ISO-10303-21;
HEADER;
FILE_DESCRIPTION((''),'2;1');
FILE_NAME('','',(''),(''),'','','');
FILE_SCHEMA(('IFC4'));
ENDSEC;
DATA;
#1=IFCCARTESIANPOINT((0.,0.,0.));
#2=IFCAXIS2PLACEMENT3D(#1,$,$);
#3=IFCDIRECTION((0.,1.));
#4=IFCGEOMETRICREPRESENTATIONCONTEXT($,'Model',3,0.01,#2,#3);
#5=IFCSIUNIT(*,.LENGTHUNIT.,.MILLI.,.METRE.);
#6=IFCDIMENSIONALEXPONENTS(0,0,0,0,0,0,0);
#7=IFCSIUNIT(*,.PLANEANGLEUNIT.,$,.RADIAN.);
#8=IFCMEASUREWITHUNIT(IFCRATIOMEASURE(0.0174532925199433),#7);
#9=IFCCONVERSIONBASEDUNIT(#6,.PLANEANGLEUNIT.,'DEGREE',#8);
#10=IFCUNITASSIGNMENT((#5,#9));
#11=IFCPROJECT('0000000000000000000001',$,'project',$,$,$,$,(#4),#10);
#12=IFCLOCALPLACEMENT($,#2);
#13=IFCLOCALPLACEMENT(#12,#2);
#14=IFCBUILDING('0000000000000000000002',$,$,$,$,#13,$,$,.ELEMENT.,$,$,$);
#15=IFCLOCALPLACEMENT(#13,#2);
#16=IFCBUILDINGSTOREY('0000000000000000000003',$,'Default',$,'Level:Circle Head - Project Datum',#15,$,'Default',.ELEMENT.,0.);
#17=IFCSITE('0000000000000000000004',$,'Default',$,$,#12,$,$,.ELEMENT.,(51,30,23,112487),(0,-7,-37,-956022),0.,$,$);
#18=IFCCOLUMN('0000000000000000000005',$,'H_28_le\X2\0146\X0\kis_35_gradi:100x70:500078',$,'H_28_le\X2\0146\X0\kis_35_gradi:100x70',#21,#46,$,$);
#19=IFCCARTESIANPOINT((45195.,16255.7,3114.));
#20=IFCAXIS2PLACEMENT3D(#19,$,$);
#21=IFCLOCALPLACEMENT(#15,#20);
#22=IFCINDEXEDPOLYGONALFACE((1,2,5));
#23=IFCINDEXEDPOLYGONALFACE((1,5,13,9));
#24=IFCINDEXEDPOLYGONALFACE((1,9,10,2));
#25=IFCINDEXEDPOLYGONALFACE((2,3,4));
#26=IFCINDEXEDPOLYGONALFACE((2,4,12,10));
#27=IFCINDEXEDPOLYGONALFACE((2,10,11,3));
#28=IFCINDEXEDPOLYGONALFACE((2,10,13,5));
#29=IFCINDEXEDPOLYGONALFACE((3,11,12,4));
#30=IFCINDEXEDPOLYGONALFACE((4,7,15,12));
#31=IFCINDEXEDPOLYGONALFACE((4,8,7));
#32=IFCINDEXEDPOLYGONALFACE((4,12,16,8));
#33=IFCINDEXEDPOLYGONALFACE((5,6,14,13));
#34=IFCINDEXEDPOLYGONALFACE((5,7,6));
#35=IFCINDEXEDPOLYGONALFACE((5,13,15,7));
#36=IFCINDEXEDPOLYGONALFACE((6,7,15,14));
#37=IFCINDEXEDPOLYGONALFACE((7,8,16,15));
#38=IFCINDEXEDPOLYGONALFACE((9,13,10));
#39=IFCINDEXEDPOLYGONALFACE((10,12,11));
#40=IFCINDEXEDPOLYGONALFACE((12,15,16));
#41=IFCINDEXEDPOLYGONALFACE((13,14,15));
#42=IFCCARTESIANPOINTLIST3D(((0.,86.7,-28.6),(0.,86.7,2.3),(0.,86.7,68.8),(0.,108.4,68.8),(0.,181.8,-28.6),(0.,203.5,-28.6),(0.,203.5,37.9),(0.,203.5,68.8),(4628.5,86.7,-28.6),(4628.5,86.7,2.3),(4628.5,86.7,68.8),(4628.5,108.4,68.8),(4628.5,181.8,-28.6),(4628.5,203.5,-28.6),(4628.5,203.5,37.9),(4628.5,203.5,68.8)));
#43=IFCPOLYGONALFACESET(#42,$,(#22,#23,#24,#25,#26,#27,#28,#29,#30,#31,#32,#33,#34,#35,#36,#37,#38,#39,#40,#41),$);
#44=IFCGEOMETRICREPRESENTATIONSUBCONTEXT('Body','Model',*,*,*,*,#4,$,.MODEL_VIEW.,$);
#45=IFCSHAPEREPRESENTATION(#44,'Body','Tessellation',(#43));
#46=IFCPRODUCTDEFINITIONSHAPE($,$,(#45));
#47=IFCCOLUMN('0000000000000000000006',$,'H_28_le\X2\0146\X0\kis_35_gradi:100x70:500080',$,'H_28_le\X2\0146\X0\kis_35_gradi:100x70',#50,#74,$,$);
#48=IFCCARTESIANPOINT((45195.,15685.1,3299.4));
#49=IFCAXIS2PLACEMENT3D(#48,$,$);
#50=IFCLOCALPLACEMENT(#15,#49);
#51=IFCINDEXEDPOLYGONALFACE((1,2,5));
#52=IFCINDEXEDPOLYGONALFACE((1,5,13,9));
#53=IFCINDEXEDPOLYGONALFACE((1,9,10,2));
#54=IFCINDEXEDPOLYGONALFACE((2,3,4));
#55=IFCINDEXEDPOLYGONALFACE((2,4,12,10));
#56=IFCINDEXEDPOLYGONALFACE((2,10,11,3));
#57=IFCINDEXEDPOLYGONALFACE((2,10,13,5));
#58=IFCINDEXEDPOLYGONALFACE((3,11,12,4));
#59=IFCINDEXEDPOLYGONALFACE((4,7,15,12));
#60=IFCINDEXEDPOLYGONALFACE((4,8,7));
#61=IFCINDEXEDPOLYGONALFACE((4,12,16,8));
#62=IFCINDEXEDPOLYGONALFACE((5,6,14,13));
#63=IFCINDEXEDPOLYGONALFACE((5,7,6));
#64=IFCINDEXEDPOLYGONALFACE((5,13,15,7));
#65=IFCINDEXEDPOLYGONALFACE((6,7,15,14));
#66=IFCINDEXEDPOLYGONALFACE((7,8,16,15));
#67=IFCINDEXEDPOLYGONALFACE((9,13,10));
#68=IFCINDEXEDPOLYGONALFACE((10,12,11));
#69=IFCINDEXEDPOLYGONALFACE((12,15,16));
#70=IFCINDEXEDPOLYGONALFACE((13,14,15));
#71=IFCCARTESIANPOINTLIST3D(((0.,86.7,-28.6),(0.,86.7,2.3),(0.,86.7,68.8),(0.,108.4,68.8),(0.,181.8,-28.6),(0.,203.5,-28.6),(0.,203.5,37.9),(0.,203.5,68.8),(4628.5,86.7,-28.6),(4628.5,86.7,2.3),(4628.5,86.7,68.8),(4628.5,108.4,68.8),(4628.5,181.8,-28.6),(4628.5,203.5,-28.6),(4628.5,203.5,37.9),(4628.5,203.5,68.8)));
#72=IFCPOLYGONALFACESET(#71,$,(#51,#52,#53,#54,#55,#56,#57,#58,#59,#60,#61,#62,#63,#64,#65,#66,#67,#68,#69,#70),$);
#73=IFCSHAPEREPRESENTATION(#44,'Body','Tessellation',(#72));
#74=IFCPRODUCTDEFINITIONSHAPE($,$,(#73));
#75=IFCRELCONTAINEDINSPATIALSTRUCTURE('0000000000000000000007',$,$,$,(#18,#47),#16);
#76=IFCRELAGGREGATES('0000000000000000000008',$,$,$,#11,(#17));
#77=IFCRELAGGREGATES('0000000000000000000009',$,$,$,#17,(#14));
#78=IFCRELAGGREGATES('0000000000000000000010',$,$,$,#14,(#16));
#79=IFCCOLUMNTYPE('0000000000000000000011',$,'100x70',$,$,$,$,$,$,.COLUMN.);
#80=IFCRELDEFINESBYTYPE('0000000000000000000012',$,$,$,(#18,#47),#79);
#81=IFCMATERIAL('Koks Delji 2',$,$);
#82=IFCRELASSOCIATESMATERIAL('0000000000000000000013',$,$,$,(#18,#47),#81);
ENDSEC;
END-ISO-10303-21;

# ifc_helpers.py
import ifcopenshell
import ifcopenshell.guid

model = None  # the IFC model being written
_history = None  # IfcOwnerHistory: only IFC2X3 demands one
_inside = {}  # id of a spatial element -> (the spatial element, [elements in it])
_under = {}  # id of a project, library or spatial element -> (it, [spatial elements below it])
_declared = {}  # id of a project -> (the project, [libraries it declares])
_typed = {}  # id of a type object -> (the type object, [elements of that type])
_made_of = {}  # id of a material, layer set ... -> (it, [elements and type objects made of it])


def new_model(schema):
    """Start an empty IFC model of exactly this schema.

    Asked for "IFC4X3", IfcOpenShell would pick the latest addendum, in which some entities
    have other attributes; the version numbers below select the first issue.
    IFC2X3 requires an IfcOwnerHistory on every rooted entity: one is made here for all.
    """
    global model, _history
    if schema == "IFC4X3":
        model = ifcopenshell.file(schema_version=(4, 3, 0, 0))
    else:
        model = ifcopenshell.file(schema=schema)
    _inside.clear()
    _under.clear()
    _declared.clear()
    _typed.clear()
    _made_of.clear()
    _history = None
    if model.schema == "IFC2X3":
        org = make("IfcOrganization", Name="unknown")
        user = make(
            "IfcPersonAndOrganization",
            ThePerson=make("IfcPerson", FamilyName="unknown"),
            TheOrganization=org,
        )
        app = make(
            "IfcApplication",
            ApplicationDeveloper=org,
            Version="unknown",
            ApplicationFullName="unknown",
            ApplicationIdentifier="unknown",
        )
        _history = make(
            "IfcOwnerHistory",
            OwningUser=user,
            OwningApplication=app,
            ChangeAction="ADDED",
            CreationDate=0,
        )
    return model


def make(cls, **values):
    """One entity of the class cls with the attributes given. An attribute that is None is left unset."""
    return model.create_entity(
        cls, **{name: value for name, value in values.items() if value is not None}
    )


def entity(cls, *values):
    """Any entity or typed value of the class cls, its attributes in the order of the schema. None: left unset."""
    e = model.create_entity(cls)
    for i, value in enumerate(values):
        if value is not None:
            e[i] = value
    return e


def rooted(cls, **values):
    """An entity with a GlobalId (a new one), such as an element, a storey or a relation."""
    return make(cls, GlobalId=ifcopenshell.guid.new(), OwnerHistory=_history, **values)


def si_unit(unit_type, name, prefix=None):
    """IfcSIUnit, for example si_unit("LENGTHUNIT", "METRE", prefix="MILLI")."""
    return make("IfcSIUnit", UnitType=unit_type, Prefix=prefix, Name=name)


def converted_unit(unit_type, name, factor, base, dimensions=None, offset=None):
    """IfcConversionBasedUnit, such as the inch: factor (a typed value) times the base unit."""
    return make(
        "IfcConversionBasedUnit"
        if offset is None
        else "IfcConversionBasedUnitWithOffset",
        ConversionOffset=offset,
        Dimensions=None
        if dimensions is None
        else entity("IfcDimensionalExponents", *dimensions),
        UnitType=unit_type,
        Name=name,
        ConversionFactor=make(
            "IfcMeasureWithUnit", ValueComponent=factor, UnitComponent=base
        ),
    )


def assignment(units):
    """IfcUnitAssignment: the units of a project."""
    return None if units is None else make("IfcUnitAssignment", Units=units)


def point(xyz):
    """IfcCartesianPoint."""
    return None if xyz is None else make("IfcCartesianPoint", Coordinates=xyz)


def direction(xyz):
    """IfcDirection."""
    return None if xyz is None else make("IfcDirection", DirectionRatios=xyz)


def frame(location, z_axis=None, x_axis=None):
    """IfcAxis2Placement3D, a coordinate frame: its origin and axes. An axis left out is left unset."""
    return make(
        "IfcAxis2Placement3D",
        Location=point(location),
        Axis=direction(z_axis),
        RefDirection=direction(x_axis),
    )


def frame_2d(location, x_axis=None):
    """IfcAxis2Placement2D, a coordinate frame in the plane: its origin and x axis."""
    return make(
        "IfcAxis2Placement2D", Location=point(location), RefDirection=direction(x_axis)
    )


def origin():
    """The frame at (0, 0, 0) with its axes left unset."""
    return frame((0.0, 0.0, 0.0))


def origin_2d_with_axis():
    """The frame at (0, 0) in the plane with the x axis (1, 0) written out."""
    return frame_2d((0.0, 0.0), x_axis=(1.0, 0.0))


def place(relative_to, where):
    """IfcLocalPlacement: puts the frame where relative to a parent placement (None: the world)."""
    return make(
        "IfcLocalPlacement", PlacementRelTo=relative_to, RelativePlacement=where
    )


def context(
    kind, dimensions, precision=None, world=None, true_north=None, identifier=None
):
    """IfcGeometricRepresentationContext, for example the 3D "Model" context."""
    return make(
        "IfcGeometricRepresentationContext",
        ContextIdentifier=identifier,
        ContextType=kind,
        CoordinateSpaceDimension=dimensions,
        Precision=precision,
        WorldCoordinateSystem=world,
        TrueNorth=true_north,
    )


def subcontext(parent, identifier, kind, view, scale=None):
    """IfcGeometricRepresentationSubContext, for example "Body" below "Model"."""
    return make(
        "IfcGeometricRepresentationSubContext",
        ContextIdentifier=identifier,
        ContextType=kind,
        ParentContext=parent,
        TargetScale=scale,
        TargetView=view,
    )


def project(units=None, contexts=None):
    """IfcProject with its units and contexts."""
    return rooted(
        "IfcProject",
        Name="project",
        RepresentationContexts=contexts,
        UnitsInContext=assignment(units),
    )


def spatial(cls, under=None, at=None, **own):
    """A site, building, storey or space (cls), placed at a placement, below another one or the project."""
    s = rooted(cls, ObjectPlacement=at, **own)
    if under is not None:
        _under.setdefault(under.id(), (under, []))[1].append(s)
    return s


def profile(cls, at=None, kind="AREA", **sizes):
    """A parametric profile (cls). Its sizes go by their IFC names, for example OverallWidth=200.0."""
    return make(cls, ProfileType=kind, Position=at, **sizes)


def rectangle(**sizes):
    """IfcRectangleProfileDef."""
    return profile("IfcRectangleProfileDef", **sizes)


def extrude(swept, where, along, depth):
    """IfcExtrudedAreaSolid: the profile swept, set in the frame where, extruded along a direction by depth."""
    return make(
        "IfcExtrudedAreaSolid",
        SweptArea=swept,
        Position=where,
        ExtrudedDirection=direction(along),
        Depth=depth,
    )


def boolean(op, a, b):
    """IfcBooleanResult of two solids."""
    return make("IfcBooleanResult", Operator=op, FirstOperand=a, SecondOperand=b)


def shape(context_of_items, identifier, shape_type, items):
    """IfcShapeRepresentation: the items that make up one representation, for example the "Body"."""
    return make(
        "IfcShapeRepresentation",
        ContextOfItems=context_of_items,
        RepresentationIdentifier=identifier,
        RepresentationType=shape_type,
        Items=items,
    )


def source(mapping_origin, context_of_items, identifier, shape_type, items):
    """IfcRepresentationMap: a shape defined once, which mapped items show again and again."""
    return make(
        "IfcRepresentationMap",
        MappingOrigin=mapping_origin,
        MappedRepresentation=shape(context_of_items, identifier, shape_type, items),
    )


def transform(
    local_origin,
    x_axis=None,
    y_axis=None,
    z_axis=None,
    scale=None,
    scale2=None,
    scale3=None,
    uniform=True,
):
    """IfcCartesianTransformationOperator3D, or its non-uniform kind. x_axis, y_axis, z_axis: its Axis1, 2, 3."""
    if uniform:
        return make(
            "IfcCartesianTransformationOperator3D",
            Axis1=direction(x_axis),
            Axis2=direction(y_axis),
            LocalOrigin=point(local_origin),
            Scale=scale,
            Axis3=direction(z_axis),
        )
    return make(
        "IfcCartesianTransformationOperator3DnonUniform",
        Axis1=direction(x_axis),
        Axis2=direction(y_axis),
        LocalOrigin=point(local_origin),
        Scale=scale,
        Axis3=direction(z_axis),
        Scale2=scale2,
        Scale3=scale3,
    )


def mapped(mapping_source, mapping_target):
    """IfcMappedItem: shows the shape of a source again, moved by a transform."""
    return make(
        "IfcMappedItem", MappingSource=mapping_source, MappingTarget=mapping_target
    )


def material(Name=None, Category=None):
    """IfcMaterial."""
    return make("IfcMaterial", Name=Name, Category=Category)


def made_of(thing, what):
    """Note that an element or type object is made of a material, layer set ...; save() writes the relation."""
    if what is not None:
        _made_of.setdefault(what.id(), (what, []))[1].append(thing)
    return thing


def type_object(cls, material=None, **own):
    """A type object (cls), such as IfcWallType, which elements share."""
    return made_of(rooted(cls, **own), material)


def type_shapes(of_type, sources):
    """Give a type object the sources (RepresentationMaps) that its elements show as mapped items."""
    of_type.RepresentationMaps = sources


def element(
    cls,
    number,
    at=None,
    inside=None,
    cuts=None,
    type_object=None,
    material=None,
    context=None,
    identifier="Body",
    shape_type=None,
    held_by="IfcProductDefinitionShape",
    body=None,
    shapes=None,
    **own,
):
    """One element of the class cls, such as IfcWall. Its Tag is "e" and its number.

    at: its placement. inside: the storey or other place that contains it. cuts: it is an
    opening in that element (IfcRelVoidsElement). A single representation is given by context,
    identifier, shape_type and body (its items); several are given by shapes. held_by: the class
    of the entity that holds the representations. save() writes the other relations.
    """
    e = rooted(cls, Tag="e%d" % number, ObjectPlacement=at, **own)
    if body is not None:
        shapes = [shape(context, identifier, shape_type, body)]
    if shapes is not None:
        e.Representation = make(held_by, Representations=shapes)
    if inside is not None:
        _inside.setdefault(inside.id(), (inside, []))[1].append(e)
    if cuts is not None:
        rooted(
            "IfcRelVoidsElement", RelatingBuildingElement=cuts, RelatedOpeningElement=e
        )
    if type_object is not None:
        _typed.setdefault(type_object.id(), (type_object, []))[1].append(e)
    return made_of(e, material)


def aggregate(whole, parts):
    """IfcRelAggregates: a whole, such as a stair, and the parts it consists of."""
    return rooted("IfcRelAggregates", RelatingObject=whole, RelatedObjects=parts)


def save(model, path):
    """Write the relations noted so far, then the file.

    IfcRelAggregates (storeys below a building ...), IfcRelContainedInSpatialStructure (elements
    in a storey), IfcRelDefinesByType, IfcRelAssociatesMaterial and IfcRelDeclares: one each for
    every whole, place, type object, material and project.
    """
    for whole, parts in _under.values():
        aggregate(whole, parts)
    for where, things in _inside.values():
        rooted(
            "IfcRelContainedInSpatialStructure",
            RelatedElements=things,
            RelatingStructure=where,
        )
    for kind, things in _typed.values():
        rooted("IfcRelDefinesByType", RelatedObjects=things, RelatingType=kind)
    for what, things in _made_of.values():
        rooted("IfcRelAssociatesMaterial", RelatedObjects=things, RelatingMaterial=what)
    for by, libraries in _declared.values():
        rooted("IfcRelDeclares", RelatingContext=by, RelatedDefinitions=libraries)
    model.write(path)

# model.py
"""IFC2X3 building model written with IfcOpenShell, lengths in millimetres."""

from ifc_helpers import new_model, entity, si_unit, converted_unit, direction, frame, frame_2d, origin, origin_2d_with_axis, place, context, subcontext, project, spatial, rectangle, extrude, boolean, source, transform, mapped, material, type_object, type_shapes, element, save


model = new_model("IFC2X3")

# Units and contexts
model_context = context("Model", 3, precision=0.01, world=origin(), true_north=direction((0.0, 1.0)))
body_context = subcontext(model_context, "Body", "Model", "MODEL_VIEW")
ifc_project = project(units=[si_unit("LENGTHUNIT", "METRE", prefix="MILLI"), converted_unit("PLANEANGLEUNIT", "DEGREE", entity("IfcRatioMeasure", 0.0174532925199433), si_unit("PLANEANGLEUNIT", "RADIAN"), dimensions=[0, 0, 0, 0, 0, 0, 0])], contexts=[model_context])

# Site, building, storey
site_placement = place(None, origin())
site = spatial("IfcSite", under=ifc_project, at=site_placement, Name="Default", CompositionType="ELEMENT", RefLatitude=(51, 30, 23, 112487), RefLongitude=(0, -7, -37, -956022), RefElevation=0.0)
building_placement = place(site_placement, origin())
building = spatial("IfcBuilding", under=site, at=building_placement, CompositionType="ELEMENT")
storey_placement = place(building_placement, origin())
storey = spatial("IfcBuildingStorey", under=building, at=storey_placement, Name="Default", ObjectType="Level:Circle Head - Project Datum", LongName="Default", CompositionType="ELEMENT", Elevation=0.0)

# Columns
ifc_material_1 = material(Name="Koks Delji 2")
column_type = type_object("IfcColumnType", Name="100x70", PredefinedType="COLUMN")
shared_shape_1 = source(origin(), body_context, "Body", "CSG", [
    boolean("DIFFERENCE", extrude(rectangle(XDim=4628.5, YDim=116.7, at=origin_2d_with_axis()), frame((2314.3, 145.1, -28.6)), (0.0, 0.0, 1.0), 97.5), extrude(rectangle(XDim=70.0, YDim=100.0, at=frame_2d((0.0, 0.0), x_axis=(0.0, 1.0))), frame((4628.5, 145.1, 20.1), z_axis=(1.0, 0.0, 0.0), x_axis=(0.0, 0.951057, -0.309017)), (0.0, 0.0, -1.0), 4628.5)),
])
type_shapes(column_type, [shared_shape_1])
for number, where, name in (
    (1, (45195.0, 16255.7, 3114.0), "H_28_leņkis_35_gradi:100x70:500078"),
    (2, (45195.0, 15685.1, 3299.4), "H_28_leņkis_35_gradi:100x70:500080"),
):
    element("IfcColumn", number, at=place(storey_placement, frame(where)), inside=storey, type_object=column_type, material=ifc_material_1, Name=name, ObjectType="H_28_leņkis_35_gradi:100x70", context=body_context, shape_type="MappedRepresentation", body=[
        mapped(shared_shape_1, transform((0.0, 0.0, 0.0), scale=1.0)),
    ])

save(model, "model.ifc")
